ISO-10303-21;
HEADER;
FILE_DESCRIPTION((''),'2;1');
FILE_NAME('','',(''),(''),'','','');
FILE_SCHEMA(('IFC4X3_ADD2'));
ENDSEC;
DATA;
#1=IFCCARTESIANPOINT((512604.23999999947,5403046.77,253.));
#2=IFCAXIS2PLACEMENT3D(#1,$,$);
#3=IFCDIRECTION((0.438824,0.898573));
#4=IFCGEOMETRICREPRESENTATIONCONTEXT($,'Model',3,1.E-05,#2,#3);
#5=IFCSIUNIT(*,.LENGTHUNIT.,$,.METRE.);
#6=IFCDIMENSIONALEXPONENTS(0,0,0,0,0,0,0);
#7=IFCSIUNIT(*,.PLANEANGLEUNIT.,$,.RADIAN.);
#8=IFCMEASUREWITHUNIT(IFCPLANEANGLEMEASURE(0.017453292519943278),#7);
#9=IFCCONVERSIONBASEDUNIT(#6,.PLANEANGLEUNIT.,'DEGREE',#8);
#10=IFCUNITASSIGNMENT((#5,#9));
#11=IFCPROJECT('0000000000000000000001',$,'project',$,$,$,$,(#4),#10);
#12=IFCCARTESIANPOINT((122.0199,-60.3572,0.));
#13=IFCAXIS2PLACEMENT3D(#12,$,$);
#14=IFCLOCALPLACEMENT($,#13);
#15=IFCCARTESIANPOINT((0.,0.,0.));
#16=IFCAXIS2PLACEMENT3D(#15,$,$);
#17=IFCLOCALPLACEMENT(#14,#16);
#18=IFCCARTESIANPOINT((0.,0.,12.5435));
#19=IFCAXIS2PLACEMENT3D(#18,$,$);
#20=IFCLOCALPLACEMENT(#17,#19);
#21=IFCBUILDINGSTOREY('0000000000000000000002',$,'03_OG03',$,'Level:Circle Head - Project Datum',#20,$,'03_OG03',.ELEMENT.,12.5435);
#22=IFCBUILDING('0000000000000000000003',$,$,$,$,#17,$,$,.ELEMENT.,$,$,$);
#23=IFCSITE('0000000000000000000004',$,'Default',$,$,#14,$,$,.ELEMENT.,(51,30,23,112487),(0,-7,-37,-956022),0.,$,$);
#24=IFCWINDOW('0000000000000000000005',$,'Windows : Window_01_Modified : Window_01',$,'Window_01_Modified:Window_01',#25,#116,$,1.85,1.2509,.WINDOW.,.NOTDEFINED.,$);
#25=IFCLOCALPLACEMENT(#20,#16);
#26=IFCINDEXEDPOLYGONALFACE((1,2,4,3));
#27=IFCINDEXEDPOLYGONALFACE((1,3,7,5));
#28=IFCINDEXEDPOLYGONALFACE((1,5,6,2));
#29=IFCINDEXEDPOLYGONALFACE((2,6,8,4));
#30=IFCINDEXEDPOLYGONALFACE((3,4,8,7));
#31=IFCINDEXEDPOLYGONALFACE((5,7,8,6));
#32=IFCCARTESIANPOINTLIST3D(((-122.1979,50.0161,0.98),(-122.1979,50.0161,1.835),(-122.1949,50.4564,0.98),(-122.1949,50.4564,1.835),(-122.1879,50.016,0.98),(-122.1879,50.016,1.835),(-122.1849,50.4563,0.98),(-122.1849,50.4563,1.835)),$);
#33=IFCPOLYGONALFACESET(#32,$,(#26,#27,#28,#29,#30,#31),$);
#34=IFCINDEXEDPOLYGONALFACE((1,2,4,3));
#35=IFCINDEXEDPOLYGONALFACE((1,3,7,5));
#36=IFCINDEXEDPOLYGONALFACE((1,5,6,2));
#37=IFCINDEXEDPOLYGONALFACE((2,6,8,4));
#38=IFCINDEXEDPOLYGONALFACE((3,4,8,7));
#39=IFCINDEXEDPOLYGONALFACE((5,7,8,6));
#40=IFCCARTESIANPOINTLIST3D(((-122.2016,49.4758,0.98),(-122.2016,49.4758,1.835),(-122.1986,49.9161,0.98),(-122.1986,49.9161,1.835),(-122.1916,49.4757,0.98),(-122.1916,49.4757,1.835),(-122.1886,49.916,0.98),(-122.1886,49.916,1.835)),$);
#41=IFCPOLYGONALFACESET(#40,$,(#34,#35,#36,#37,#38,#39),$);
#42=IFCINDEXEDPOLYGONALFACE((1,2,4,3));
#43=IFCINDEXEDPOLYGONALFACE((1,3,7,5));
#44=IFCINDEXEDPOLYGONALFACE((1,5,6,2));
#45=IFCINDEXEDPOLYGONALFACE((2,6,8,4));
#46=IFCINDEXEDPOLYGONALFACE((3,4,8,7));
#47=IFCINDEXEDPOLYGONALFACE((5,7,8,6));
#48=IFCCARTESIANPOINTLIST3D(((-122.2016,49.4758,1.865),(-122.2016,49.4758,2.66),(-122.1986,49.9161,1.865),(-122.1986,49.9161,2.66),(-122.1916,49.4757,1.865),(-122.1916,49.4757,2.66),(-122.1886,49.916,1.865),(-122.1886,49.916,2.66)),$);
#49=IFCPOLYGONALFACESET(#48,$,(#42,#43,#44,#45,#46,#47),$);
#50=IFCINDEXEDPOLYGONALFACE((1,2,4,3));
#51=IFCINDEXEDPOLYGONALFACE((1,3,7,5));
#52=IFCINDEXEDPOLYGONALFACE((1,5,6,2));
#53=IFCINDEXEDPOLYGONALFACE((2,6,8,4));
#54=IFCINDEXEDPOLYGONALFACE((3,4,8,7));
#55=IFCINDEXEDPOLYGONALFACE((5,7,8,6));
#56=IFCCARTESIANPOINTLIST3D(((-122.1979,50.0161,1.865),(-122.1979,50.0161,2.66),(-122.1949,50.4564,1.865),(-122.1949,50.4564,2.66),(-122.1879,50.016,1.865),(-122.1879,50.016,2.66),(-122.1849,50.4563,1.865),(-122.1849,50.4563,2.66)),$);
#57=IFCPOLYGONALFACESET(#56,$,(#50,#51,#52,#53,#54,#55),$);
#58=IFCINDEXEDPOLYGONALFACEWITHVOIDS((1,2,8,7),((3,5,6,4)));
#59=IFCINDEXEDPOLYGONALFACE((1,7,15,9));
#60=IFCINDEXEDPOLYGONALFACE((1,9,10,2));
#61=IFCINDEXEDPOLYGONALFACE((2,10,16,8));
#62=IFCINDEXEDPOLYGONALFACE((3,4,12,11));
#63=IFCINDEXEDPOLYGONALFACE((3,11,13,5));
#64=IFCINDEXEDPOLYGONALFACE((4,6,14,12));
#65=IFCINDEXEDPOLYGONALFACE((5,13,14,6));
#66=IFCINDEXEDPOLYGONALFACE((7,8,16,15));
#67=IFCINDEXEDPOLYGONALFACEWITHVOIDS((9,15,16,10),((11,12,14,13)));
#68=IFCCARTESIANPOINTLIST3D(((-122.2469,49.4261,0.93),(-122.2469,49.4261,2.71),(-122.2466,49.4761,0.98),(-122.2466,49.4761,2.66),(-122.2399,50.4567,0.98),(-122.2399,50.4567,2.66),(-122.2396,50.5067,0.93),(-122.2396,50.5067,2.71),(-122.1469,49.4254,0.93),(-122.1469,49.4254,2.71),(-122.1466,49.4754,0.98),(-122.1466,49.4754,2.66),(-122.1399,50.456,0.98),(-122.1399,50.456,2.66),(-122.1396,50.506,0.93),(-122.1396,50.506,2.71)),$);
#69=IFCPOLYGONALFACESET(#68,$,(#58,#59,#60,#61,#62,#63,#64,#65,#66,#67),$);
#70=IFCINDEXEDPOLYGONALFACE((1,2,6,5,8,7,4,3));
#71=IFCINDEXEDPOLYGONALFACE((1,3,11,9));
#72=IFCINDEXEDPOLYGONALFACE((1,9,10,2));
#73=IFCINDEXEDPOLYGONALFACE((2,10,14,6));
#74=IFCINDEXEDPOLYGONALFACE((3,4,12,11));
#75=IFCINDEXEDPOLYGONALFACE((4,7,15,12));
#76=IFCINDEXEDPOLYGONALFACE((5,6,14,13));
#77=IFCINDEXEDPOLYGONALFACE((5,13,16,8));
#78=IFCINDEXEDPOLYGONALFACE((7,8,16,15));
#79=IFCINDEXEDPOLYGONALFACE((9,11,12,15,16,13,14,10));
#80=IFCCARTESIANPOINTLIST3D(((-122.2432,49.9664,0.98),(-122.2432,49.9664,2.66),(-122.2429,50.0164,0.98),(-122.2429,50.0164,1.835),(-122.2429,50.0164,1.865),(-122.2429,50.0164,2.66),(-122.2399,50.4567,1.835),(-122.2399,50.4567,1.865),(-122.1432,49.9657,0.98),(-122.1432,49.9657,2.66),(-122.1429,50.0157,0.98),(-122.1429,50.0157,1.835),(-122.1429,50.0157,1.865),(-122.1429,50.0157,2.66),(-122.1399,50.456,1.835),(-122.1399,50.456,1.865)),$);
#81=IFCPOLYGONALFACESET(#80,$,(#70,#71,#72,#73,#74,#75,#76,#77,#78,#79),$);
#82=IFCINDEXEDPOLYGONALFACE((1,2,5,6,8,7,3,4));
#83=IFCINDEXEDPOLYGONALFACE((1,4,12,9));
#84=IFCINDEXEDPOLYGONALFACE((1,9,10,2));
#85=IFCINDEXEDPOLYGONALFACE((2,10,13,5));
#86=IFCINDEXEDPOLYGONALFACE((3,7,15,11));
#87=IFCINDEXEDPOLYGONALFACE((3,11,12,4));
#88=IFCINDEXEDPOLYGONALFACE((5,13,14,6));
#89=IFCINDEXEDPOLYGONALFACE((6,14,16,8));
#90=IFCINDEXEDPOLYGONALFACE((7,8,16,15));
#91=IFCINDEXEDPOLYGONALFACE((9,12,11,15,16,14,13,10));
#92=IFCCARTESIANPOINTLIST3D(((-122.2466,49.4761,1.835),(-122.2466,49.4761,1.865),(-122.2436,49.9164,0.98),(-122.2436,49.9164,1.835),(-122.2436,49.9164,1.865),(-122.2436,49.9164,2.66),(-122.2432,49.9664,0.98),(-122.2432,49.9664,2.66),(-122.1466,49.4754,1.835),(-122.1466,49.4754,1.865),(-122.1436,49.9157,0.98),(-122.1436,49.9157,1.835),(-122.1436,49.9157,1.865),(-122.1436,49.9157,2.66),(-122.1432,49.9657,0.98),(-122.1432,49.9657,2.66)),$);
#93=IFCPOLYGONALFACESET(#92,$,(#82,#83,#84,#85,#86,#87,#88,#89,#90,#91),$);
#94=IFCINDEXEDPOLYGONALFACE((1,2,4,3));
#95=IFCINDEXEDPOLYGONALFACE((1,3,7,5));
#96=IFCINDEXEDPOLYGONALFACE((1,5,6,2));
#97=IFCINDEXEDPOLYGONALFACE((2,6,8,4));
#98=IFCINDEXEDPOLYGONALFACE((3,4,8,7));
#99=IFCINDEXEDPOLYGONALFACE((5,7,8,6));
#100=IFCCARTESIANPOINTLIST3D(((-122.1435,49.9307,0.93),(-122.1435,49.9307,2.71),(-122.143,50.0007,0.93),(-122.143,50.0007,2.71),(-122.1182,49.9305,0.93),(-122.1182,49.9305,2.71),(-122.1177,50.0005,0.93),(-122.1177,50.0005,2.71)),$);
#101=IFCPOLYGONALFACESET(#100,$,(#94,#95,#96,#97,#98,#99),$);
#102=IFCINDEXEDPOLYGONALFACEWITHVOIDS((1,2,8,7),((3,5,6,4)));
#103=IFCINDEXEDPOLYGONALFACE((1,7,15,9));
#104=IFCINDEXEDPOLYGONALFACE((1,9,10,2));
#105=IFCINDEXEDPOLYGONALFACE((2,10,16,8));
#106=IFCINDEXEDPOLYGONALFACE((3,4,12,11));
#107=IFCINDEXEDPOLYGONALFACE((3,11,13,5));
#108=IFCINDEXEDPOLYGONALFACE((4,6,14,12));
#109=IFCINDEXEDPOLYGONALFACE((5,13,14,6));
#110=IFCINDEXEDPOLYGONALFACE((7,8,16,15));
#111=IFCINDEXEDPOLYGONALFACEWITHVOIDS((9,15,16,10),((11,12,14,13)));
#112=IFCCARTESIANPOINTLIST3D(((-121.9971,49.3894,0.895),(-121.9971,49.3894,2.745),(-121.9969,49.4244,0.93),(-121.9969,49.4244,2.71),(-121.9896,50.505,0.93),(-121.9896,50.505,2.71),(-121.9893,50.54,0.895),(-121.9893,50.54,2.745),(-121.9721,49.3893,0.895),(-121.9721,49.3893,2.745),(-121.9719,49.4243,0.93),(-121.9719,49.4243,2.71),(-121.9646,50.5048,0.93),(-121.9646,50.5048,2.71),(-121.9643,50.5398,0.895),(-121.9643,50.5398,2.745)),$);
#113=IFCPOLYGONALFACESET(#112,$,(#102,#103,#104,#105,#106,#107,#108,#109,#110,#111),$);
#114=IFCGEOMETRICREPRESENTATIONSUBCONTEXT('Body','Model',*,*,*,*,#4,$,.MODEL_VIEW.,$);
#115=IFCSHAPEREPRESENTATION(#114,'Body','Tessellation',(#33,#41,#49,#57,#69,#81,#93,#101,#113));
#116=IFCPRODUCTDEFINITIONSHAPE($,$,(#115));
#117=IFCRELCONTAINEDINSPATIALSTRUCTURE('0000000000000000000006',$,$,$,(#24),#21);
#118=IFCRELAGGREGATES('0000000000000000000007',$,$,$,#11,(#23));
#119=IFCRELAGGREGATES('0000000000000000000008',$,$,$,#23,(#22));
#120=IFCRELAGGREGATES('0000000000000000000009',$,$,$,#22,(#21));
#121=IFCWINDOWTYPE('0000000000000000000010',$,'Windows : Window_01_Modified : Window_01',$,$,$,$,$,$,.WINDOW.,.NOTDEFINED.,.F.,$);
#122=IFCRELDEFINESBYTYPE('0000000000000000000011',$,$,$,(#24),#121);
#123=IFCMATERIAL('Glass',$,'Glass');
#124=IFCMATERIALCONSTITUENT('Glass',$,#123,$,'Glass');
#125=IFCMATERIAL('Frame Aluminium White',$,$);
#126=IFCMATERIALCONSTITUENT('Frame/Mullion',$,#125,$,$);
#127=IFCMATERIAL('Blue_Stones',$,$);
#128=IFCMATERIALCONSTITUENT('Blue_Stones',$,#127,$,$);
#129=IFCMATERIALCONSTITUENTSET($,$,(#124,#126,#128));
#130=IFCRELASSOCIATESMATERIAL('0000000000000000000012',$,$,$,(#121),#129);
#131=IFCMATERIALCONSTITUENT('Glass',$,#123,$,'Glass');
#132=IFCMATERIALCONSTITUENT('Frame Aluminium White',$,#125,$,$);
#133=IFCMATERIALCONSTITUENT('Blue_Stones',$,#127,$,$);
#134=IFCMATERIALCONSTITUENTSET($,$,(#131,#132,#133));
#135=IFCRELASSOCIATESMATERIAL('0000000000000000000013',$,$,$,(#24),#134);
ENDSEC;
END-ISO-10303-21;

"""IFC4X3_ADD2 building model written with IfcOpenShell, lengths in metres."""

from ifc_helpers import new_model, entity, si_unit, converted_unit, direction, frame, frame_2d, origin, place, context, subcontext, project, spatial, polyline, rectangle, outline, extrude, source, transform, mapped, material, constituent, constituent_set, type_object, type_shapes, element, save


model = new_model("IFC4X3_ADD2")

# Units and contexts
model_context = context("Model", 3, precision=1e-05, world=frame((512604.23999999947, 5403046.77, 253.0)), true_north=direction((0.438824, 0.898573)))
body_context = subcontext(model_context, "Body", "Model", "MODEL_VIEW")
ifc_project = project(units=[si_unit("LENGTHUNIT", "METRE"), converted_unit("PLANEANGLEUNIT", "DEGREE", entity("IfcPlaneAngleMeasure", 0.017453292519943278), si_unit("PLANEANGLEUNIT", "RADIAN"), dimensions=[0, 0, 0, 0, 0, 0, 0])], contexts=[model_context])

# Site, building, storey
site_placement = place(None, frame((122.0199, -60.3572, 0.0)))
site = spatial("IfcSite", under=ifc_project, at=site_placement, Name="Default", CompositionType="ELEMENT", RefLatitude=(51, 30, 23, 112487), RefLongitude=(0, -7, -37, -956022), RefElevation=0.0)
building_placement = place(site_placement, origin())
building = spatial("IfcBuilding", under=site, at=building_placement, CompositionType="ELEMENT")
storey_placement = place(building_placement, frame((0.0, 0.0, 12.5435)))
storey = spatial("IfcBuildingStorey", under=building, at=storey_placement, Name="03_OG03", ObjectType="Level:Circle Head - Project Datum", LongName="03_OG03", CompositionType="ELEMENT", Elevation=12.5435)

# Window
ifc_material_1 = material(Name="Glass", Category="Glass")
ifc_material_2 = material(Name="Frame Aluminium White")
ifc_material_3 = material(Name="Blue_Stones")
ifc_constituent_1 = constituent(ifc_material_1, Name="Glass", Category="Glass")
ifc_constituent_2 = constituent(ifc_material_2, Name="Frame Aluminium White")
ifc_constituent_3 = constituent(ifc_material_3, Name="Blue_Stones")
ifc_constituent_set_1 = constituent_set(constituents=[ifc_constituent_1, ifc_constituent_2, ifc_constituent_3])
ifc_constituent_4 = constituent(ifc_material_1, Name="Glass", Category="Glass")
ifc_constituent_5 = constituent(ifc_material_2, Name="Frame/Mullion")
ifc_constituent_6 = constituent(ifc_material_3, Name="Blue_Stones")
ifc_constituent_set_2 = constituent_set(constituents=[ifc_constituent_4, ifc_constituent_5, ifc_constituent_6])
window_type_1 = type_object("IfcWindowType", Name="Windows : Window_01_Modified : Window_01", ParameterTakesPrecedence=False, PartitioningType="NOTDEFINED", PredefinedType="WINDOW", material=ifc_constituent_set_2)
shared_shape_1 = source(origin(), body_context, "Body", "SweptSolid", [
    extrude(rectangle(XDim=0.4403, YDim=0.01, at=frame_2d((0.0, 0.0), x_axis=(1.0, 0.0))), frame((0.3059, -0.2, 0.0514), z_axis=(0.0, 0.0, 1.0), x_axis=(-1.0, 0.0, 0.0)), (0.0, 0.0, 1.0), 0.855),
    extrude(rectangle(XDim=0.01, YDim=0.4403, at=frame_2d((0.0, 0.0), x_axis=(1.0, 0.0))), frame((0.8462, -0.2, 0.0514), z_axis=(0.0, 0.0, 1.0), x_axis=(0.0, 1.0, 0.0)), (0.0, 0.0, 1.0), 0.855),
    extrude(rectangle(XDim=0.4403, YDim=0.01, at=frame_2d((0.0, 0.0), x_axis=(1.0, 0.0))), frame((0.8462, -0.2, 0.9364), z_axis=(0.0, 0.0, 1.0), x_axis=(-1.0, 0.0, 0.0)), (0.0, 0.0, 1.0), 0.795),
    extrude(rectangle(XDim=0.4403, YDim=0.01, at=frame_2d((0.0, 0.0), x_axis=(1.0, 0.0))), frame((0.3059, -0.2, 0.9364), z_axis=(0.0, 0.0, 1.0), x_axis=(-1.0, 0.0, 0.0)), (0.0, 0.0, 1.0), 0.795),
    extrude(outline(polyline([(-0.89, -0.5403), (0.89, -0.5403), (0.89, 0.5403), (-0.89, 0.5403), (-0.89, -0.5403)]), holes=[polyline([(0.84, 0.4903), (0.84, -0.4903), (-0.84, -0.4903), (-0.84, 0.4903), (0.84, 0.4903)])]), frame((0.5761, -0.25, 0.8914), z_axis=(0.0, 1.0, 0.0), x_axis=(0.0, 0.0, 1.0)), (0.0, 0.0, 1.0), 0.1),
    extrude(outline(polyline([(0.03, 0.0976), (0.825, 0.0976), (0.825, 0.1476), (-0.855, 0.1476), (-0.855, 0.0976), (0.0, 0.0976), (0.0, -0.3427), (0.03, -0.3427), (0.03, 0.0976)])), frame((0.4285, -0.25, 0.9064), z_axis=(0.0, 1.0, 0.0), x_axis=(0.0, 0.0, 1.0)), (0.0, 0.0, 1.0), 0.1),
    extrude(outline(polyline([(-0.825, -0.0976), (-0.825, -0.1476), (0.855, -0.1476), (0.855, -0.0976), (0.0, -0.0976), (0.0, 0.3427), (-0.03, 0.3427), (-0.03, -0.0976), (-0.825, -0.0976)])), frame((0.7236, -0.25, 0.9064), z_axis=(0.0, -1.0, 0.0), x_axis=(0.0, 0.0, -1.0)), (0.0, 0.0, -1.0), 0.1),
    extrude(rectangle(XDim=0.0253, YDim=0.07, at=frame_2d((0.0, 0.0), x_axis=(1.0, 0.0))), frame((0.5761, -0.1374, 0.0014), z_axis=(0.0, 0.0, 1.0), x_axis=(0.0, -1.0, 0.0)), (0.0, 0.0, 1.0), 1.78),
    extrude(outline(polyline([(-0.5753, -0.925), (0.5753, -0.925), (0.5753, 0.925), (-0.5753, 0.925), (-0.5753, -0.925)]), holes=[polyline([(-0.5403, -0.89), (-0.5403, 0.89), (0.5403, 0.89), (0.5403, -0.89), (-0.5403, -0.89)])]), frame((0.5761, 0.0, 0.8914), z_axis=(0.0, 1.0, 0.0), x_axis=(1.0, 0.0, 0.0)), (0.0, 0.0, 1.0), 0.025),
])
type_shapes(window_type_1, [shared_shape_1])
window_1_placement = place(storey_placement, frame((-121.9893, 50.5408, 0.9286), z_axis=(0.0, 0.0, 1.0), x_axis=(-0.0068, -0.999977, 0.0)))
element("IfcWindow", 1, at=window_1_placement, inside=storey, type_object=window_type_1, material=ifc_constituent_set_1, Name="Windows : Window_01_Modified : Window_01", ObjectType="Window_01_Modified:Window_01", OverallHeight=1.85, OverallWidth=1.2509, PartitioningType="NOTDEFINED", PredefinedType="WINDOW", context=body_context, shape_type="MappedRepresentation", body=[
    mapped(shared_shape_1, transform((0.0, 0.0, 0.0), scale=1.0)),
])

save(model, "model.ifc")
